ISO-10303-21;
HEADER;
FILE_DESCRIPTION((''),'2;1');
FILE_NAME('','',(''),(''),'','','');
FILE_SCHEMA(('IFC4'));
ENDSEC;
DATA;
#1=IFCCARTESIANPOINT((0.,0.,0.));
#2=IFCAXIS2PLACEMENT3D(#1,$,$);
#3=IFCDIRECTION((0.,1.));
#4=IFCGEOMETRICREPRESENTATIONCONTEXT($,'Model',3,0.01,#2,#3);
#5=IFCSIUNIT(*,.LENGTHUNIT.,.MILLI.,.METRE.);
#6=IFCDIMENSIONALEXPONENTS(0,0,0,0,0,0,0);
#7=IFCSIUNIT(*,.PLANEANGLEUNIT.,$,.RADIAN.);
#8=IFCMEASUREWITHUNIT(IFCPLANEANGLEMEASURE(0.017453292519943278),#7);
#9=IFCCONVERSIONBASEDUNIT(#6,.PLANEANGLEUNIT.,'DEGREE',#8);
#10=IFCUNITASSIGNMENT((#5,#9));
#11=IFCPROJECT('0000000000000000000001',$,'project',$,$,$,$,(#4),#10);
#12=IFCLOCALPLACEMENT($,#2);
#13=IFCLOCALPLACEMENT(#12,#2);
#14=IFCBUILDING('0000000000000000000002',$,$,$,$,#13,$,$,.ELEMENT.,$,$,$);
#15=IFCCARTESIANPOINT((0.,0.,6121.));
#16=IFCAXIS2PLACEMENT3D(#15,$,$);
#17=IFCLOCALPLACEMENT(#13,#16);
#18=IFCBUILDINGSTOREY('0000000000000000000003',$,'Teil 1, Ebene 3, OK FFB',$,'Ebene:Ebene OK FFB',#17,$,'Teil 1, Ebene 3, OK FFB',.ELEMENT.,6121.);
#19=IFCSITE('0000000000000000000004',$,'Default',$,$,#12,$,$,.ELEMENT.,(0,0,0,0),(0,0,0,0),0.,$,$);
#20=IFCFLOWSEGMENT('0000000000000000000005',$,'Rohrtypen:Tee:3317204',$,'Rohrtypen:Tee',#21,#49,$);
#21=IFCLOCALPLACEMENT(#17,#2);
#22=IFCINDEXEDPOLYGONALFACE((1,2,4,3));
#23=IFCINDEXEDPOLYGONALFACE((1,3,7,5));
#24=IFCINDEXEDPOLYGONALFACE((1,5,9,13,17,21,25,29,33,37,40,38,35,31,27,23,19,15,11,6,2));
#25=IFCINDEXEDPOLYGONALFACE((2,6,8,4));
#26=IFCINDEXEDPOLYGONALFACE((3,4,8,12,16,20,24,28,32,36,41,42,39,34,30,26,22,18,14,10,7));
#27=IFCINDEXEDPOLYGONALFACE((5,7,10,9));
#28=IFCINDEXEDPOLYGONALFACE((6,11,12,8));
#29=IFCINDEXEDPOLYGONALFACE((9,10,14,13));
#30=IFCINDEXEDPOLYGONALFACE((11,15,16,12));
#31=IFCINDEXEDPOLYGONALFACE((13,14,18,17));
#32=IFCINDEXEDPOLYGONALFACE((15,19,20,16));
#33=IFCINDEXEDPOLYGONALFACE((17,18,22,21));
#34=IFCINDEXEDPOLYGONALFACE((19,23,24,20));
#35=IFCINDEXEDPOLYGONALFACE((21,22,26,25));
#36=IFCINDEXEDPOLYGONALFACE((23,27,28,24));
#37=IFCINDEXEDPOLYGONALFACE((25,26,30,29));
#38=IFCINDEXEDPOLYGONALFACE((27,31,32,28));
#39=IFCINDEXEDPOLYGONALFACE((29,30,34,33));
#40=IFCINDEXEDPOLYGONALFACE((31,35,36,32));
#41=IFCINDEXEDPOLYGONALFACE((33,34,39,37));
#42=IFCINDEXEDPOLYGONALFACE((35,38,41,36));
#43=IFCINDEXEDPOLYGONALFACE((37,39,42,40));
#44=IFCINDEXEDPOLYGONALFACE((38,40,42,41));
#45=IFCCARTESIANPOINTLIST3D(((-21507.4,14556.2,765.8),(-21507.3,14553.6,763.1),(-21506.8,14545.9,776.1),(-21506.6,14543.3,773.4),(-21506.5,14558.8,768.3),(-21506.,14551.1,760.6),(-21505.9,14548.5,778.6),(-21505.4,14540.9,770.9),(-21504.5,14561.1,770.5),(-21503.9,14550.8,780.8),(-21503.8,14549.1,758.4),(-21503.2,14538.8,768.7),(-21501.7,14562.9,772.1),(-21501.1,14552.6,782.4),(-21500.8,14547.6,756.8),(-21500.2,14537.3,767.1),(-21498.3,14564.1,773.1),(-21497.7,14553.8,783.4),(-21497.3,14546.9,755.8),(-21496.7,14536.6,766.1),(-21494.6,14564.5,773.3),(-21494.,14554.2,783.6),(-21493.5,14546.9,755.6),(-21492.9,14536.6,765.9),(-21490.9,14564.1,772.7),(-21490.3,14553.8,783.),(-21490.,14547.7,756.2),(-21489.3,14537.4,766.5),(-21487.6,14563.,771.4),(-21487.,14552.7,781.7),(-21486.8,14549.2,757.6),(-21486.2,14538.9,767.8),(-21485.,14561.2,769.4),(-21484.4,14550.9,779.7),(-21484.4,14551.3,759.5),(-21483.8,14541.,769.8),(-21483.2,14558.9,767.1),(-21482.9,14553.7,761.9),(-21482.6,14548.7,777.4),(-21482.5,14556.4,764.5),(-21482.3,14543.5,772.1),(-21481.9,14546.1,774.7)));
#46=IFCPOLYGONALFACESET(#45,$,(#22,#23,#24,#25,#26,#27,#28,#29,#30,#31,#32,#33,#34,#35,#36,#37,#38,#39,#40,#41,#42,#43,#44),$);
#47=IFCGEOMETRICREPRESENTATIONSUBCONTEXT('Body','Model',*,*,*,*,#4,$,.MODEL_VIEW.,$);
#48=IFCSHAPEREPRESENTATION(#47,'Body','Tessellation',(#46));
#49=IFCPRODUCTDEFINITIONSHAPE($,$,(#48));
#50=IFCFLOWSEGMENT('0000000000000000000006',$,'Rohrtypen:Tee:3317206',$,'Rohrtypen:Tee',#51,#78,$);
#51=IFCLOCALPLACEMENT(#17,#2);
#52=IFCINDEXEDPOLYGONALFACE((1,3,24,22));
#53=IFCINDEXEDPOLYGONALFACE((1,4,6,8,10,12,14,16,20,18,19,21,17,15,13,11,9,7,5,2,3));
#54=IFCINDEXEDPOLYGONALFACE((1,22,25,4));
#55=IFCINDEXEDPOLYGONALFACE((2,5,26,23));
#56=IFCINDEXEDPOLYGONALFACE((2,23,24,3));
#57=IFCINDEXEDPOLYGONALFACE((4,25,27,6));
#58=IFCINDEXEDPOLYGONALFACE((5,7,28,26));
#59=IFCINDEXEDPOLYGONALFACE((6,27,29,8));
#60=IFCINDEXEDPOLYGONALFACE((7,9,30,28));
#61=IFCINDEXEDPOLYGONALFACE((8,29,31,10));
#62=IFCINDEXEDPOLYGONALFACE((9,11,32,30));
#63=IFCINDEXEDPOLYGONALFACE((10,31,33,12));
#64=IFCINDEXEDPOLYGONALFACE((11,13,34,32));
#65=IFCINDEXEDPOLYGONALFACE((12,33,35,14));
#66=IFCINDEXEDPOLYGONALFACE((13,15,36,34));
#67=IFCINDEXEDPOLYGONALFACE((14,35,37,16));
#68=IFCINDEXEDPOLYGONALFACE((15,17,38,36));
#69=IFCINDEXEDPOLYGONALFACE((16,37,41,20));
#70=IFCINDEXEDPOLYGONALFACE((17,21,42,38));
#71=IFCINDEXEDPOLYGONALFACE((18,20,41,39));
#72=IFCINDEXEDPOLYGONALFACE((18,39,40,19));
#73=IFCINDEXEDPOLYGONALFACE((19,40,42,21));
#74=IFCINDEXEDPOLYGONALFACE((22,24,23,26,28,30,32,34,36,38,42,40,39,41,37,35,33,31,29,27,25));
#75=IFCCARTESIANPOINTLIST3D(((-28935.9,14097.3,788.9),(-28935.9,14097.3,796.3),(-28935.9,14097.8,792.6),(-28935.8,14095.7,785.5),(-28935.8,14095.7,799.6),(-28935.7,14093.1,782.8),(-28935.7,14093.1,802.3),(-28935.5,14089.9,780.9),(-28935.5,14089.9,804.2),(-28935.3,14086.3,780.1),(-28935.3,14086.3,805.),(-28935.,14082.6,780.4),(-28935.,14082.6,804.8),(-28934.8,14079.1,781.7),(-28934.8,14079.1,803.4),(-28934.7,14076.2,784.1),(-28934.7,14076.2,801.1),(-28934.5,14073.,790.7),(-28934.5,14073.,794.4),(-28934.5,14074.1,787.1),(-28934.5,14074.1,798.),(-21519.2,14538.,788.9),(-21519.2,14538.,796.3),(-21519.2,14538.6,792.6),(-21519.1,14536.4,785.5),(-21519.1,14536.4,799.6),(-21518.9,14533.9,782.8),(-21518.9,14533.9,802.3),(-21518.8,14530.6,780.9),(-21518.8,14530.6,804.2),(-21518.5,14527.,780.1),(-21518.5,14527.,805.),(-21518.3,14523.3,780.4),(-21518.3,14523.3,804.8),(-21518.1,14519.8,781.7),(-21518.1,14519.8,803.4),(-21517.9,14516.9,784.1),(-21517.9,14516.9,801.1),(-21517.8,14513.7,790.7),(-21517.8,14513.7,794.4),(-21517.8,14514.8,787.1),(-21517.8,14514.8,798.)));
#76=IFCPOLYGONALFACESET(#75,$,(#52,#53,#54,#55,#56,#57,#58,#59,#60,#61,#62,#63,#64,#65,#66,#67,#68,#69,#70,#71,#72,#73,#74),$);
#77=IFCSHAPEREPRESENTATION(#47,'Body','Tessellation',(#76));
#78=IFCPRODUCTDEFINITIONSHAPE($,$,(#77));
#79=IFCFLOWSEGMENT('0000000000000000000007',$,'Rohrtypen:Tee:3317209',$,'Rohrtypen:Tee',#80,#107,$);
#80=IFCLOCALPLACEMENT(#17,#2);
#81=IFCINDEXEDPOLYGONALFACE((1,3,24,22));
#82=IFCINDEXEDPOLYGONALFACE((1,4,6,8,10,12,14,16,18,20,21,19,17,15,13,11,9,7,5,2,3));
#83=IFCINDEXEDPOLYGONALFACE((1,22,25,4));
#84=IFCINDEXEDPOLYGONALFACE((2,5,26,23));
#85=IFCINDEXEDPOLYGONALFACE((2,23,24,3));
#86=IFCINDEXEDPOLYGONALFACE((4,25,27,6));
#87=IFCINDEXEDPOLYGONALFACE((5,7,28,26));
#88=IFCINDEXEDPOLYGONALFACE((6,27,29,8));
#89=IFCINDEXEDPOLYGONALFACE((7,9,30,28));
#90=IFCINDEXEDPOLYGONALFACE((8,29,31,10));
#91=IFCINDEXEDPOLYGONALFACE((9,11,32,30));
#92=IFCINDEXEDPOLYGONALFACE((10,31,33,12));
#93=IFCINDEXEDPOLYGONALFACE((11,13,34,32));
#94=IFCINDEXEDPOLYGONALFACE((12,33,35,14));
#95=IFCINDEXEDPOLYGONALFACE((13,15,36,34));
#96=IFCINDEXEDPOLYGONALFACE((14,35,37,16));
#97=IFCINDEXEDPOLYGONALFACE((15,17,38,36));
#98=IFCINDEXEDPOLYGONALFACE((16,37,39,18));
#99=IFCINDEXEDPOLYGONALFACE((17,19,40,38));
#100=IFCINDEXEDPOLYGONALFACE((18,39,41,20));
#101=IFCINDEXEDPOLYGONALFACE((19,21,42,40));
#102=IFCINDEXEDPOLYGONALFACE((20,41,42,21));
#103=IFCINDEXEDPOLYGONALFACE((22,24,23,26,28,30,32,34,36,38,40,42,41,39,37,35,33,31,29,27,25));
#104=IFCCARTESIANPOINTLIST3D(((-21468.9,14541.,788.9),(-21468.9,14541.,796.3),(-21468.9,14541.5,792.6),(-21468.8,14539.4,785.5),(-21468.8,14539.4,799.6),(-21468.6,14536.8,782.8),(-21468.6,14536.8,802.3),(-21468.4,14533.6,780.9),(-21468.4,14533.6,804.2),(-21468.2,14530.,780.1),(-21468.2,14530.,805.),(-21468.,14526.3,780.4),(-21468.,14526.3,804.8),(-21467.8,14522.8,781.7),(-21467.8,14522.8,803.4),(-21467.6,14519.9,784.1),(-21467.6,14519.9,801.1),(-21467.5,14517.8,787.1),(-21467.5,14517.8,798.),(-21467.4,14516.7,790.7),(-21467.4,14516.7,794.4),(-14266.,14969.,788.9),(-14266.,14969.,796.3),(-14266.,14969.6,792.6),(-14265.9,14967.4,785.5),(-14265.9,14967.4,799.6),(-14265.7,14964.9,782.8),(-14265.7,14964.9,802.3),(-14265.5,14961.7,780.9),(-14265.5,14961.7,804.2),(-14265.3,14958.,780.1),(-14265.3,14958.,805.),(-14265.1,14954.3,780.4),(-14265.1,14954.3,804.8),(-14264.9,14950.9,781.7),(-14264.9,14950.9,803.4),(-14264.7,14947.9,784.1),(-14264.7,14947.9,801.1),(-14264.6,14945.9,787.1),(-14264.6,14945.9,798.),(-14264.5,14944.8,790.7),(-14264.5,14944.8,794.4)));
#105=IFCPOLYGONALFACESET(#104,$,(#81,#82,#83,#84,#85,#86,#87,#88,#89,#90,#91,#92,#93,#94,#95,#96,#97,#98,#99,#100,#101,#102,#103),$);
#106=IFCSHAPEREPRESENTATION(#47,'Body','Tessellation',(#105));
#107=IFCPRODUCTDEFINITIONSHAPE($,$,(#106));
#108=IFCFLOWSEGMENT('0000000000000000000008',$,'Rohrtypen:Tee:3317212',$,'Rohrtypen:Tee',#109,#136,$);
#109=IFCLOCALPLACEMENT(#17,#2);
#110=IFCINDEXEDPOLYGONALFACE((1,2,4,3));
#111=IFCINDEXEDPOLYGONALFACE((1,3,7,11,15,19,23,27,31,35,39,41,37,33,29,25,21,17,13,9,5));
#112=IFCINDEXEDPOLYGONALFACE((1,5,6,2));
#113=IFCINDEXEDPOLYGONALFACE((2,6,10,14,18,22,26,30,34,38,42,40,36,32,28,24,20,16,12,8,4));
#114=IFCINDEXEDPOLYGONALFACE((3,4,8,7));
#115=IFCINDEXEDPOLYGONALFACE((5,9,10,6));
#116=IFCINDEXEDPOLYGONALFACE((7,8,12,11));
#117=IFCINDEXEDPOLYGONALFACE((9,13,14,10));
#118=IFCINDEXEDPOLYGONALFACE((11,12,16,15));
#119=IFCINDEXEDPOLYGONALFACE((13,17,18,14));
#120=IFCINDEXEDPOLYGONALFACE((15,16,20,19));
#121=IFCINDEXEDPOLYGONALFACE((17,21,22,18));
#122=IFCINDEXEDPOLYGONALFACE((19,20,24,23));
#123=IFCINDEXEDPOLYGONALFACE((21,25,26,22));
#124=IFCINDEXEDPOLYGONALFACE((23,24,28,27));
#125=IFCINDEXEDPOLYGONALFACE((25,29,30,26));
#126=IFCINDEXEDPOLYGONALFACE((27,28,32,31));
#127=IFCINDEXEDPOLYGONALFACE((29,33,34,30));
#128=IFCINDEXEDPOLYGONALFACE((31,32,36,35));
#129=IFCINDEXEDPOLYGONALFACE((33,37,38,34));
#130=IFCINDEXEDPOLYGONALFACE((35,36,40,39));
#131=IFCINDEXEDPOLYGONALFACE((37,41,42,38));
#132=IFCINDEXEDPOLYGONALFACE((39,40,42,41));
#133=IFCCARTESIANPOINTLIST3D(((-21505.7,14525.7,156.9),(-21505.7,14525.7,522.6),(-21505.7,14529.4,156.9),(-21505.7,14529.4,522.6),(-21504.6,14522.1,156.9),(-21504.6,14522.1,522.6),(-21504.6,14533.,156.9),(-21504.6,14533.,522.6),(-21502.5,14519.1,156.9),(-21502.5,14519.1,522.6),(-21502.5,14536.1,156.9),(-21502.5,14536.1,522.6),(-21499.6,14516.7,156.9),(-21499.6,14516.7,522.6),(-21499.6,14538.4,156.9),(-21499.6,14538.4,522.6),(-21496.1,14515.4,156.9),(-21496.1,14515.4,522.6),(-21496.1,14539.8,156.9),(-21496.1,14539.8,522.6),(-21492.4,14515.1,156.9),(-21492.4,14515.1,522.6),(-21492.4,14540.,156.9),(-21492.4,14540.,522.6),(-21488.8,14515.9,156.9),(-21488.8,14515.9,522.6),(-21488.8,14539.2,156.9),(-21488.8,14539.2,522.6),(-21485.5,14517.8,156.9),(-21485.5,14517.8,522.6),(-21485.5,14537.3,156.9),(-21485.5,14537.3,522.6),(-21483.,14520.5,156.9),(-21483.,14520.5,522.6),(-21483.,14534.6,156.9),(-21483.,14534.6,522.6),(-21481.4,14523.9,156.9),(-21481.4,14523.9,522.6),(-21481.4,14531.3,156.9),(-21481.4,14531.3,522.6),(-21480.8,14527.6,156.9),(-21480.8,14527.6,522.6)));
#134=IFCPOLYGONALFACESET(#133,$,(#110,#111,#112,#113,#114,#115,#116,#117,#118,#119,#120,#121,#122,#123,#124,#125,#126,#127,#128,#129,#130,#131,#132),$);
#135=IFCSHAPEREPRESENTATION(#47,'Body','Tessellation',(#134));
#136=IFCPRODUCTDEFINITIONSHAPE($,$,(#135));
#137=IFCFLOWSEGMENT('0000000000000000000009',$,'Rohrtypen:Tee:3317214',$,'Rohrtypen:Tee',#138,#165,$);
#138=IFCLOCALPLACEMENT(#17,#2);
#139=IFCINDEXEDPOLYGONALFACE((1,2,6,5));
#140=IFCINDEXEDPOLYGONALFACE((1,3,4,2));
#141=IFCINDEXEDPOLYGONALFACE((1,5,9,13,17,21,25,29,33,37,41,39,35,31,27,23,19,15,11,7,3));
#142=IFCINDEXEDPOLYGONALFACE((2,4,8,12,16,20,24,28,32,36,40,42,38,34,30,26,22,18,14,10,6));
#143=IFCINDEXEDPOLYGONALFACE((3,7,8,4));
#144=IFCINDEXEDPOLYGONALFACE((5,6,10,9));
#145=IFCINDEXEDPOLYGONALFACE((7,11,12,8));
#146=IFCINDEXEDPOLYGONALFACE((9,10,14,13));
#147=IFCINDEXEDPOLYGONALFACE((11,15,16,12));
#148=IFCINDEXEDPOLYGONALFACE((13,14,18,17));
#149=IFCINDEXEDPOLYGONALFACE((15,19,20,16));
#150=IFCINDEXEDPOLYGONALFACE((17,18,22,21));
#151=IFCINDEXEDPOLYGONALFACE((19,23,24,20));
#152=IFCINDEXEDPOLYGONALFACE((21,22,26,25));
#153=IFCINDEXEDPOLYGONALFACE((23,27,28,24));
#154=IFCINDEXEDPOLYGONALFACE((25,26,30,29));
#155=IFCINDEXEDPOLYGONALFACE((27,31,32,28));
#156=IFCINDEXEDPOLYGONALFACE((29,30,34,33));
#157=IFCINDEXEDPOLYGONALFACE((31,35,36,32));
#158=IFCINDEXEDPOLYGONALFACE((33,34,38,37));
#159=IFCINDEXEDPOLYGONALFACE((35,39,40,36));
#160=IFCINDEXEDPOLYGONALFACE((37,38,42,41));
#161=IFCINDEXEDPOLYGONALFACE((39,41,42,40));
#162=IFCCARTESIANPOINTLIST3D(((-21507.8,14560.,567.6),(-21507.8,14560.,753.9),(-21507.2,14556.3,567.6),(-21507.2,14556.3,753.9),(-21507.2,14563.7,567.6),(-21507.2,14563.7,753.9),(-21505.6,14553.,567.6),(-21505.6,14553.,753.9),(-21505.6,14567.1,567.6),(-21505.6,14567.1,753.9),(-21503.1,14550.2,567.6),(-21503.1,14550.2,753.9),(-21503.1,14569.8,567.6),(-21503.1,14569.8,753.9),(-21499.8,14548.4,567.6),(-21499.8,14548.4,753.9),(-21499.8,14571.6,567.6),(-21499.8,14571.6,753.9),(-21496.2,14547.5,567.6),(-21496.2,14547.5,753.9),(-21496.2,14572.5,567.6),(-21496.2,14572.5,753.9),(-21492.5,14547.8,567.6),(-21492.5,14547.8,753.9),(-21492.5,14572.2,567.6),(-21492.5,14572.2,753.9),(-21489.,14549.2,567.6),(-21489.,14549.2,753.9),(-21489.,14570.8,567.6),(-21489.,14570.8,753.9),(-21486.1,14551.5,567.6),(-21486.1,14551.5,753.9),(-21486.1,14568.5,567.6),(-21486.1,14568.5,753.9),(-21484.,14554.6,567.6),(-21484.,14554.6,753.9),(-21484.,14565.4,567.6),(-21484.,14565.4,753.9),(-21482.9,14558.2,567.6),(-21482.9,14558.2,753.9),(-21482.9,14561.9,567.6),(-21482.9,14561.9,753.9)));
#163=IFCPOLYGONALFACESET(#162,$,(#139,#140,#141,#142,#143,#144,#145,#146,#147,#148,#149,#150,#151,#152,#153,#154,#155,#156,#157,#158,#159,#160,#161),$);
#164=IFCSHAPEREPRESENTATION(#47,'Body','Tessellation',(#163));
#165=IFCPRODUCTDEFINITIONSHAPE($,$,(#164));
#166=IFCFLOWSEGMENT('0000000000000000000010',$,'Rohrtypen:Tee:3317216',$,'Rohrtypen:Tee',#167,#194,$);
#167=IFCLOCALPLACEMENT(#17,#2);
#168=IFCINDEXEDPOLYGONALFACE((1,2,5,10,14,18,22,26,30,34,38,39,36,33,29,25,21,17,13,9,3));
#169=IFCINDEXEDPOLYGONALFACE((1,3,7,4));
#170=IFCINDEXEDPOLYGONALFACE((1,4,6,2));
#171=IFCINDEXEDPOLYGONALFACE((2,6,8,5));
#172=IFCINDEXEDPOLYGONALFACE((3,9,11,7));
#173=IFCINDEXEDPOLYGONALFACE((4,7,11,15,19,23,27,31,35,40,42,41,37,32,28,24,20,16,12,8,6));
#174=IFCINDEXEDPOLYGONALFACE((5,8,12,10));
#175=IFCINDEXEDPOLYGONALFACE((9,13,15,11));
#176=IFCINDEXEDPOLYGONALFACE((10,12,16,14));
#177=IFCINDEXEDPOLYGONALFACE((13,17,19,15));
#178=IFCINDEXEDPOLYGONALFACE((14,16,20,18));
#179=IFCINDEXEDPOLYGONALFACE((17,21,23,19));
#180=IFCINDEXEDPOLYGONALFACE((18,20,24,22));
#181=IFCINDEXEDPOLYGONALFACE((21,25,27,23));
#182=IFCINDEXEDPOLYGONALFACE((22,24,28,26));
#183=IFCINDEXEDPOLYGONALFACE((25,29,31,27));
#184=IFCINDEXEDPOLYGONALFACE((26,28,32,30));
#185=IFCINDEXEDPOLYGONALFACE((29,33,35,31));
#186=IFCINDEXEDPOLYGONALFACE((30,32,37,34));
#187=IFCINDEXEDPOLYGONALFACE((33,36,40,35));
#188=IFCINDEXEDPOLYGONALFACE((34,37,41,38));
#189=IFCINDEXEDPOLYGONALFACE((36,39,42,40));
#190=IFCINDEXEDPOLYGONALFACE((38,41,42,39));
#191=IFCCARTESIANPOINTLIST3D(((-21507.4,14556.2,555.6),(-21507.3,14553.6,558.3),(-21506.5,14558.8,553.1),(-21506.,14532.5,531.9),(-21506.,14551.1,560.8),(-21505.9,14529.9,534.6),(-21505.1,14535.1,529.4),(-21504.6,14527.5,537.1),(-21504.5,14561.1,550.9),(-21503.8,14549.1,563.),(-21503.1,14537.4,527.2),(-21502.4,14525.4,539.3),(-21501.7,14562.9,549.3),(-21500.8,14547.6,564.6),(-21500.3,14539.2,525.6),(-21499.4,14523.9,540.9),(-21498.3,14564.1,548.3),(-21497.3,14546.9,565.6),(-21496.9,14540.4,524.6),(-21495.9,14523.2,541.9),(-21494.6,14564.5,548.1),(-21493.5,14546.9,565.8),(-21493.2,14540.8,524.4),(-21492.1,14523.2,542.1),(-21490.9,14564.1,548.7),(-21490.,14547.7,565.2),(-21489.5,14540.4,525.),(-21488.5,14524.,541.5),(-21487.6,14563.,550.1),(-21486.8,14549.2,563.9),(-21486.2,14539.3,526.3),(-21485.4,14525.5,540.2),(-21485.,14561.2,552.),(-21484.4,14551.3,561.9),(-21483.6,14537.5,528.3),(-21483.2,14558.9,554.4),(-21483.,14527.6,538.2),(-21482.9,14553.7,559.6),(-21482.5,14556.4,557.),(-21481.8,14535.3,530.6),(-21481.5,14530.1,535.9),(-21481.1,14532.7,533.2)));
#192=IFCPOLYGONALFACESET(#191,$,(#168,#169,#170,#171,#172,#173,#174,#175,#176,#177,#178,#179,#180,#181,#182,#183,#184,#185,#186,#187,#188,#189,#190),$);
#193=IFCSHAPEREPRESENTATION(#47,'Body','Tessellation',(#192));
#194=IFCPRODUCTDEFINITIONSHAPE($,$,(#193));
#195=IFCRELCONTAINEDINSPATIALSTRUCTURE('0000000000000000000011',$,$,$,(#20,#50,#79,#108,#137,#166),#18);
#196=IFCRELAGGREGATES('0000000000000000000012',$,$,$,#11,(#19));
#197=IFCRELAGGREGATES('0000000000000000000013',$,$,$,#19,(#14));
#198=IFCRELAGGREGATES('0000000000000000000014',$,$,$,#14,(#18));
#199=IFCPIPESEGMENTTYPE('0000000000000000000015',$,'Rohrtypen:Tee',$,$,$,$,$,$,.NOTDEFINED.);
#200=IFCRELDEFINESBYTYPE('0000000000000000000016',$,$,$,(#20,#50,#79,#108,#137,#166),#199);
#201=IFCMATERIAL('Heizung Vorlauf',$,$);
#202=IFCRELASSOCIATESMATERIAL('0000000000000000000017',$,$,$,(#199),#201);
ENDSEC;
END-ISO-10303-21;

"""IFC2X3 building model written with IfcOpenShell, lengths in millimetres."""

from ifc_helpers import new_model, entity, si_unit, converted_unit, direction, frame, frame_2d, origin, origin_2d_with_axis, place, context, subcontext, project, spatial, circle, extrude, material, type_object, element, save


model = new_model("IFC2X3")

# Units and contexts
model_context = context("Model", 3, precision=0.01, world=origin(), true_north=direction((0.0, 1.0)))
body_context = subcontext(model_context, "Body", "Model", "MODEL_VIEW")
ifc_project = project(units=[si_unit("LENGTHUNIT", "METRE", prefix="MILLI"), converted_unit("PLANEANGLEUNIT", "DEGREE", entity("IfcPlaneAngleMeasure", 0.017453292519943278), si_unit("PLANEANGLEUNIT", "RADIAN"), dimensions=[0, 0, 0, 0, 0, 0, 0])], contexts=[model_context])

# Site, building, storey
site_placement = place(None, origin())
site = spatial("IfcSite", under=ifc_project, at=site_placement, Name="Default", CompositionType="ELEMENT", RefLatitude=(0, 0, 0, 0), RefLongitude=(0, 0, 0, 0), RefElevation=0.0)
building_placement = place(site_placement, origin())
building = spatial("IfcBuilding", under=site, at=building_placement, CompositionType="ELEMENT")
storey_placement = place(building_placement, frame((0.0, 0.0, 6121.0)))
storey = spatial("IfcBuildingStorey", under=building, at=storey_placement, Name="Teil 1, Ebene 3, OK FFB", ObjectType="Ebene:Ebene OK FFB", LongName="Teil 1, Ebene 3, OK FFB", CompositionType="ELEMENT", Elevation=6121.0)

# Flow segments
ifc_material = material(Name="Heizung Vorlauf")
pipe_segment_type = type_object("IfcPipeSegmentType", Name="Rohrtypen:Tee", PredefinedType="NOTDEFINED", material=ifc_material)
flow_segment_1_placement = place(storey_placement, origin())
element("IfcFlowSegment", 1, at=flow_segment_1_placement, inside=storey, type_object=pipe_segment_type, Name="Rohrtypen:Tee:3317204", ObjectType="Rohrtypen:Tee", context=body_context, shape_type="SweptSolid", body=[
    extrude(circle(Radius=12.5, at=origin_2d_with_axis()), frame((-21495.0, 14555.6, 764.5), z_axis=(0.041945, -0.705862, 0.707107), x_axis=(0.998239, 0.059319, 0.0)), (0.0, 0.0, 1.0), 14.5),
])
flow_segment_2_placement = place(storey_placement, origin())
element("IfcFlowSegment", 2, at=flow_segment_2_placement, inside=storey, type_object=pipe_segment_type, Name="Rohrtypen:Tee:3317206", ObjectType="Rohrtypen:Tee", context=body_context, shape_type="SweptSolid", body=[
    extrude(circle(Radius=12.5, at=frame_2d((0.0, 0.0), x_axis=(1.0, 0.0))), frame((-28935.2, 14085.3, 792.6), z_axis=(0.998239, 0.059319, 0.0), x_axis=(-0.059319, 0.998239, 0.0)), (0.0, 0.0, 1.0), 7429.8),
])
flow_segment_3_placement = place(storey_placement, origin())
element("IfcFlowSegment", 3, at=flow_segment_3_placement, inside=storey, type_object=pipe_segment_type, Name="Rohrtypen:Tee:3317209", ObjectType="Rohrtypen:Tee", context=body_context, shape_type="SweptSolid", body=[
    extrude(circle(Radius=12.5, at=origin_2d_with_axis()), frame((-21468.2, 14529.1, 792.6), z_axis=(0.998239, 0.059319, 0.0), x_axis=(-0.059319, 0.998239, 0.0)), (0.0, 0.0, 1.0), 7215.6),
])
flow_segment_4_placement = place(storey_placement, origin())
element("IfcFlowSegment", 4, at=flow_segment_4_placement, inside=storey, type_object=pipe_segment_type, Name="Rohrtypen:Tee:3317212", ObjectType="Rohrtypen:Tee", context=body_context, shape_type="SweptSolid", body=[
    extrude(circle(Radius=12.5, at=origin_2d_with_axis()), frame((-21493.3, 14527.6, 156.9)), (0.0, 0.0, 1.0), 365.8),
])
flow_segment_5_placement = place(storey_placement, origin())
element("IfcFlowSegment", 5, at=flow_segment_5_placement, inside=storey, type_object=pipe_segment_type, Name="Rohrtypen:Tee:3317214", ObjectType="Rohrtypen:Tee", context=body_context, shape_type="SweptSolid", body=[
    extrude(circle(Radius=12.5, at=origin_2d_with_axis()), frame((-21495.3, 14560.0, 567.6), z_axis=(0.0, 0.0, 1.0), x_axis=(-1.0, 0.0, 0.0)), (0.0, 0.0, 1.0), 186.3),
])
flow_segment_6_placement = place(storey_placement, origin())
element("IfcFlowSegment", 6, at=flow_segment_6_placement, inside=storey, type_object=pipe_segment_type, Name="Rohrtypen:Tee:3317216", ObjectType="Rohrtypen:Tee", context=body_context, shape_type="SweptSolid", body=[
    extrude(circle(Radius=12.5, at=origin_2d_with_axis()), frame((-21493.6, 14532.0, 533.2), z_axis=(-0.041945, 0.705862, 0.707107), x_axis=(0.998239, 0.059319, 0.0)), (0.0, 0.0, 1.0), 33.5),
])

save(model, "model.ifc")
